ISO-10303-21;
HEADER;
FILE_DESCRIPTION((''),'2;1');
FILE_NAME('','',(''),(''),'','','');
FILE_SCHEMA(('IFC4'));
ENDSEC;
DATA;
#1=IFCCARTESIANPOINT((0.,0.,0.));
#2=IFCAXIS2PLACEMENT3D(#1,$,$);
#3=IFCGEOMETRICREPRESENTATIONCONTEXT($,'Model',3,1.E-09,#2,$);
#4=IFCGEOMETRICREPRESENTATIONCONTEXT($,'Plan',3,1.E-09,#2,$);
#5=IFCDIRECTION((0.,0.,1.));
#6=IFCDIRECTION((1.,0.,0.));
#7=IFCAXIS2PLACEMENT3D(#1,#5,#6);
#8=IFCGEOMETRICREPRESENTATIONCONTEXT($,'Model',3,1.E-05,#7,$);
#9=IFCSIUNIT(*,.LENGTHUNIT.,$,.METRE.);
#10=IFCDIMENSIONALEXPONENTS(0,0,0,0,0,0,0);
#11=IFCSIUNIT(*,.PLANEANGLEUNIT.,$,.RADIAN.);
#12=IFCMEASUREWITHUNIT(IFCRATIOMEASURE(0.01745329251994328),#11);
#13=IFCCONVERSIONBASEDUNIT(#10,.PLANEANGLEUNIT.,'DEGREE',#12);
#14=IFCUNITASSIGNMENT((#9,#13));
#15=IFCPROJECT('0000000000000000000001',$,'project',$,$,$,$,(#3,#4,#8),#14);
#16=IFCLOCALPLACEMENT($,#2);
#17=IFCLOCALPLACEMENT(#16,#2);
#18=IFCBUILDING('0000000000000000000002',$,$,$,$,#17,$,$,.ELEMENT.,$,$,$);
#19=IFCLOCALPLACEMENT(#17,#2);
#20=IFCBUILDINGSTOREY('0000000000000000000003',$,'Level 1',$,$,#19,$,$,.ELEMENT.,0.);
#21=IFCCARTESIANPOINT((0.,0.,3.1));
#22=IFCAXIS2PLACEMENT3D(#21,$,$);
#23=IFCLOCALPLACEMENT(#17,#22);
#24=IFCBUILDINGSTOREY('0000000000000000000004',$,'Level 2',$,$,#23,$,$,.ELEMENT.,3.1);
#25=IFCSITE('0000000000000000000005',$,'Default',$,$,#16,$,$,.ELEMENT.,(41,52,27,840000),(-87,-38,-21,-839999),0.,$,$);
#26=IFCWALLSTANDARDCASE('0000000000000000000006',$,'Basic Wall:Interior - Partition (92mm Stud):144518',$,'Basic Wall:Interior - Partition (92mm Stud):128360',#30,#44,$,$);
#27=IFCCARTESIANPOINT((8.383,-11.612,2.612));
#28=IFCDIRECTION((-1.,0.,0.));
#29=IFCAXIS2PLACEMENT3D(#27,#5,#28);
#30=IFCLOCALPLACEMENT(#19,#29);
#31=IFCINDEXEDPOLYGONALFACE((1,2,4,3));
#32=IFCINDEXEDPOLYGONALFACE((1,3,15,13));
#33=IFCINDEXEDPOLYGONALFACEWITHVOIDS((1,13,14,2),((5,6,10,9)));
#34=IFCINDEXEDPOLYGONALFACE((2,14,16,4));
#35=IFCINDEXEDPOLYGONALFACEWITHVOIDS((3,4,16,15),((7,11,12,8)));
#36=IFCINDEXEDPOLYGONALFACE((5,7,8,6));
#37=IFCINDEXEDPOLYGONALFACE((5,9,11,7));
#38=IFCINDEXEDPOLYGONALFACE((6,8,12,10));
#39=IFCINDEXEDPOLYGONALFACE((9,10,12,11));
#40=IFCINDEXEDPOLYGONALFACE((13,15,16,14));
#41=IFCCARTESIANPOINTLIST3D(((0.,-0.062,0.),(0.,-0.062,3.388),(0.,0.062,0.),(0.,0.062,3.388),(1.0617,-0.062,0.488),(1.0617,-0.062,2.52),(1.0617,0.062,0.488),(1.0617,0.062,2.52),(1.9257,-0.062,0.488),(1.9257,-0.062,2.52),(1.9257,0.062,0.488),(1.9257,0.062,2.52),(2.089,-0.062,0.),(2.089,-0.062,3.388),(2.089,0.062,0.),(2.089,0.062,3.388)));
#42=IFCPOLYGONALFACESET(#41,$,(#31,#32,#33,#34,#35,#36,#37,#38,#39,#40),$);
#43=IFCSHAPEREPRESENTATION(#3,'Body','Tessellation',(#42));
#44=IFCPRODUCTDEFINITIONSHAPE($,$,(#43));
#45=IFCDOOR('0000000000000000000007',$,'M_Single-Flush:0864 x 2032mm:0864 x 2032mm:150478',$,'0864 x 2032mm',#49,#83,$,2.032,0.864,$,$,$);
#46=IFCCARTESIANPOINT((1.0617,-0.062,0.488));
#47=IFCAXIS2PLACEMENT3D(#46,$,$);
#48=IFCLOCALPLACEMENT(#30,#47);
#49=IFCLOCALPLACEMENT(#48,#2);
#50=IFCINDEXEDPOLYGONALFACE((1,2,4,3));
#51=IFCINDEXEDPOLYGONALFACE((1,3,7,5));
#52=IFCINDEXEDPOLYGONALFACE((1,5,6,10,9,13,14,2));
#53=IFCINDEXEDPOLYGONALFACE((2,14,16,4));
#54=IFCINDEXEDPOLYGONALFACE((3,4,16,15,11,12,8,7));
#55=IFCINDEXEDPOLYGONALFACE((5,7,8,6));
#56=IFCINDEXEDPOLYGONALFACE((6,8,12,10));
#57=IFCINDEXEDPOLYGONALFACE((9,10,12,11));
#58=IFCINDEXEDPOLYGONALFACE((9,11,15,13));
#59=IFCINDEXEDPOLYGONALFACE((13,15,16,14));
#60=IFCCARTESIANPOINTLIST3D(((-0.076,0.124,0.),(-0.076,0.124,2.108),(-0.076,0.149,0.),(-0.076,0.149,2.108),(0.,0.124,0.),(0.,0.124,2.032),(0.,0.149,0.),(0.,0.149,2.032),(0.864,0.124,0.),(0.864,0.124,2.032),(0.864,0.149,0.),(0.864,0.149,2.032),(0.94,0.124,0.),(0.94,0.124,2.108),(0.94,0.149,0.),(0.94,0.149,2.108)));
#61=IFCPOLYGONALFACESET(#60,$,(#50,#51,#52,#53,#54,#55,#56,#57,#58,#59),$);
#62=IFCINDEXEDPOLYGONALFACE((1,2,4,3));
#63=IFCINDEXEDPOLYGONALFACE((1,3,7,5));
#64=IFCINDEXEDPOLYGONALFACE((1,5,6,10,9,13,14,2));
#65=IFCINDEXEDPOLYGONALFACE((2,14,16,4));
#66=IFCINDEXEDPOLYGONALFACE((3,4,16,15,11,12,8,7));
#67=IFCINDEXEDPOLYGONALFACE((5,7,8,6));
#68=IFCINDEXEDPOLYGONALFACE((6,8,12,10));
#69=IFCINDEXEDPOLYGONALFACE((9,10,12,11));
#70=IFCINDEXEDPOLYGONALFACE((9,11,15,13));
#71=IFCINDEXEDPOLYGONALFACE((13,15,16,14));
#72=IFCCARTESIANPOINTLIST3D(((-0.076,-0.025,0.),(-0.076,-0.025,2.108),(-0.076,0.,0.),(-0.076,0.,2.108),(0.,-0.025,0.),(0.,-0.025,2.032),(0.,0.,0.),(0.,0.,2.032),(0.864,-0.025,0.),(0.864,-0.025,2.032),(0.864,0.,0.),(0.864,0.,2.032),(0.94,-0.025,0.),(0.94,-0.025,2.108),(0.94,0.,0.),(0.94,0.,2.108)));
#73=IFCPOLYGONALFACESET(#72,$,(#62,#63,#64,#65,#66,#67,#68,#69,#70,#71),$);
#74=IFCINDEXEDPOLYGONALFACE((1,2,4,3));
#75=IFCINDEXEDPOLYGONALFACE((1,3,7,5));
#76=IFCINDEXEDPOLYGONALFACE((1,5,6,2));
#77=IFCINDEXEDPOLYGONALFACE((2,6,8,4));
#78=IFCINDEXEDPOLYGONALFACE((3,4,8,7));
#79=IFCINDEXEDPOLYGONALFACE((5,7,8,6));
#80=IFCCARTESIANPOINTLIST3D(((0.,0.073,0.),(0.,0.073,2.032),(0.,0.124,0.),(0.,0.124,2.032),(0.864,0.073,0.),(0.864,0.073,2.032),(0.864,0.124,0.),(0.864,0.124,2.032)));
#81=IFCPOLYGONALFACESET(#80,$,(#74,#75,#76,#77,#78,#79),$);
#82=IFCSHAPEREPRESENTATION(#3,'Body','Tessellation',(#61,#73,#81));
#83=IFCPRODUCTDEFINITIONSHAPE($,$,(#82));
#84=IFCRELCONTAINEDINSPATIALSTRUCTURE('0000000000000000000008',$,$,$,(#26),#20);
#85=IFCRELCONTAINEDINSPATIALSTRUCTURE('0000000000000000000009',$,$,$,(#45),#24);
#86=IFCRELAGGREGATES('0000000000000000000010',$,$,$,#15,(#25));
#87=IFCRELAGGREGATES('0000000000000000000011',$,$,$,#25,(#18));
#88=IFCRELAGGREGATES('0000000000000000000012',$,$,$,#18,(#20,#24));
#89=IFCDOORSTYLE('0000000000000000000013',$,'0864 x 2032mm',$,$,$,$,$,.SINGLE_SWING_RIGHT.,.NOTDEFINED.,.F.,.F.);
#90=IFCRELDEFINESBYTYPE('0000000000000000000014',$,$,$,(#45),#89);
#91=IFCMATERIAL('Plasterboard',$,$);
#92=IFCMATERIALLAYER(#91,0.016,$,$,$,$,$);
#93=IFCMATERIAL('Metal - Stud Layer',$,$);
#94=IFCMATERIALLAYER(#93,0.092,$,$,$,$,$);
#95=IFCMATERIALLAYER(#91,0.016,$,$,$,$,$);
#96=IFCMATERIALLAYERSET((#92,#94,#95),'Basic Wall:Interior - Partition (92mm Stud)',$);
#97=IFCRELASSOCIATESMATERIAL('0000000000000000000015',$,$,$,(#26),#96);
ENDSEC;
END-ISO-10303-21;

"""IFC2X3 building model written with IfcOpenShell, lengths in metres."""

from ifc_helpers import new_model, entity, si_unit, converted_unit, frame, frame_2d, origin, origin_with_axes, origin_2d_with_axis, place, context, project, spatial, polyline, rectangle, outline, extrude, source, transform, mapped, material, layer, layer_set, layer_usage, type_object, type_shapes, element, fill, save


model = new_model("IFC2X3")

# Units and contexts
model_context_1 = context("Model", 3, precision=1e-09, world=origin())
plan_context = context("Plan", 3, precision=1e-09, world=origin())
model_context_2 = context("Model", 3, precision=1e-05, world=origin_with_axes())
ifc_project = project(units=[si_unit("LENGTHUNIT", "METRE"), converted_unit("PLANEANGLEUNIT", "DEGREE", entity("IfcRatioMeasure", 0.01745329251994328), si_unit("PLANEANGLEUNIT", "RADIAN"), dimensions=[0, 0, 0, 0, 0, 0, 0])], contexts=[model_context_1, plan_context, model_context_2])

# Site, building, storey
site_placement = place(None, origin())
site = spatial("IfcSite", under=ifc_project, at=site_placement, Name="Default", CompositionType="ELEMENT", RefLatitude=(41, 52, 27, 840000), RefLongitude=(-87, -38, -21, -839999), RefElevation=0.0)
building_placement = place(site_placement, origin())
building = spatial("IfcBuilding", under=site, at=building_placement, CompositionType="ELEMENT")
storey_1_placement = place(building_placement, origin())
storey_1 = spatial("IfcBuildingStorey", under=building, at=storey_1_placement, Name="Level 1", CompositionType="ELEMENT", Elevation=0.0)

# Wall, opening
ifc_material_1 = material(Name="Plasterboard")
ifc_layer_1 = layer(ifc_material_1, 0.016)
ifc_material_2 = material(Name="Metal - Stud Layer")
ifc_layer_2 = layer(ifc_material_2, 0.092)
ifc_layer_3 = layer(ifc_material_1, 0.016)
ifc_layer_set = layer_set([ifc_layer_1, ifc_layer_2, ifc_layer_3], Name="Basic Wall:Interior - Partition (92mm Stud)")
ifc_layer_usage_1 = layer_usage(ifc_layer_set, "AXIS2", "NEGATIVE", 0.062)
wall_1_placement = place(storey_1_placement, frame((8.383, -11.612, 2.612), z_axis=(0.0, 0.0, 1.0), x_axis=(-1.0, 0.0, 0.0)))
wall_1 = element("IfcWallStandardCase", 1, at=wall_1_placement, inside=storey_1, material=ifc_layer_usage_1, Name="Basic Wall:Interior - Partition (92mm Stud):144518", ObjectType="Basic Wall:Interior - Partition (92mm Stud):128360", context=model_context_1, shape_type="SweptSolid", body=[
    extrude(rectangle(XDim=2.089, YDim=0.124, at=frame_2d((1.0445, 0.0), x_axis=(-1.0, 0.0))), origin(), (0.0, 0.0, 1.0), 3.388),
])
opening_placement = place(wall_1_placement, frame((1.0617, -0.062, 0.488)))
opening = element("IfcOpeningElement", 2, at=opening_placement, cuts=wall_1, ObjectType="Opening", context=model_context_1, shape_type="SweptSolid", body=[
    extrude(rectangle(XDim=0.864, YDim=2.032, at=frame_2d((1.016, 0.432), x_axis=(0.0, 1.0))), frame((0.0, 0.0, 0.0), z_axis=(0.0, 1.0, 0.0), x_axis=(0.0, 0.0, 1.0)), (0.0, 0.0, 1.0), 0.124),
])

# Shared definitions
storey_2_placement = place(building_placement, frame((0.0, 0.0, 3.1)))
storey_2 = spatial("IfcBuildingStorey", under=building, at=storey_2_placement, Name="Level 2", CompositionType="ELEMENT", Elevation=3.1)

# Door
door_style = type_object("IfcDoorStyle", Name="0864 x 2032mm", ConstructionType="NOTDEFINED", OperationType="SINGLE_SWING_RIGHT", ParameterTakesPrecedence=False, Sizeable=False)
shared_shape = source(origin(), model_context_1, "Body", "SweptSolid", [
    extrude(outline(polyline([(-0.508, -1.073), (0.508, -1.073), (0.508, 1.035), (0.432, 1.035), (0.432, -0.997), (-0.432, -0.997), (-0.432, 1.035), (-0.508, 1.035), (-0.508, -1.073)])), frame((0.432, 0.124, 1.035), z_axis=(0.0, 1.0, 0.0), x_axis=(1.0, 0.0, 0.0)), (0.0, 0.0, 1.0), 0.025),
    extrude(outline(polyline([(-1.073, -0.508), (1.035, -0.508), (1.035, -0.432), (-0.997, -0.432), (-0.997, 0.432), (1.035, 0.432), (1.035, 0.508), (-1.073, 0.508), (-1.073, -0.508)])), frame((0.432, -0.025, 1.035), z_axis=(0.0, 1.0, 0.0), x_axis=(0.0, 0.0, -1.0)), (0.0, 0.0, 1.0), 0.025),
    extrude(rectangle(XDim=0.051, YDim=0.864, at=origin_2d_with_axis()), frame((0.432, 0.0985, 0.0), z_axis=(0.0, 0.0, 1.0), x_axis=(0.0, 1.0, 0.0)), (0.0, 0.0, 1.0), 2.032),
])
type_shapes(door_style, [shared_shape])
door_placement = place(opening_placement, origin())
door = element("IfcDoor", 3, at=door_placement, inside=storey_2, type_object=door_style, Name="M_Single-Flush:0864 x 2032mm:0864 x 2032mm:150478", ObjectType="0864 x 2032mm", OverallHeight=2.032, OverallWidth=0.864, context=model_context_1, shape_type="MappedRepresentation", body=[
    mapped(shared_shape, transform((0.0, 0.0, 0.0), scale=1.0)),
])
fill(opening, door)

save(model, "model.ifc")
